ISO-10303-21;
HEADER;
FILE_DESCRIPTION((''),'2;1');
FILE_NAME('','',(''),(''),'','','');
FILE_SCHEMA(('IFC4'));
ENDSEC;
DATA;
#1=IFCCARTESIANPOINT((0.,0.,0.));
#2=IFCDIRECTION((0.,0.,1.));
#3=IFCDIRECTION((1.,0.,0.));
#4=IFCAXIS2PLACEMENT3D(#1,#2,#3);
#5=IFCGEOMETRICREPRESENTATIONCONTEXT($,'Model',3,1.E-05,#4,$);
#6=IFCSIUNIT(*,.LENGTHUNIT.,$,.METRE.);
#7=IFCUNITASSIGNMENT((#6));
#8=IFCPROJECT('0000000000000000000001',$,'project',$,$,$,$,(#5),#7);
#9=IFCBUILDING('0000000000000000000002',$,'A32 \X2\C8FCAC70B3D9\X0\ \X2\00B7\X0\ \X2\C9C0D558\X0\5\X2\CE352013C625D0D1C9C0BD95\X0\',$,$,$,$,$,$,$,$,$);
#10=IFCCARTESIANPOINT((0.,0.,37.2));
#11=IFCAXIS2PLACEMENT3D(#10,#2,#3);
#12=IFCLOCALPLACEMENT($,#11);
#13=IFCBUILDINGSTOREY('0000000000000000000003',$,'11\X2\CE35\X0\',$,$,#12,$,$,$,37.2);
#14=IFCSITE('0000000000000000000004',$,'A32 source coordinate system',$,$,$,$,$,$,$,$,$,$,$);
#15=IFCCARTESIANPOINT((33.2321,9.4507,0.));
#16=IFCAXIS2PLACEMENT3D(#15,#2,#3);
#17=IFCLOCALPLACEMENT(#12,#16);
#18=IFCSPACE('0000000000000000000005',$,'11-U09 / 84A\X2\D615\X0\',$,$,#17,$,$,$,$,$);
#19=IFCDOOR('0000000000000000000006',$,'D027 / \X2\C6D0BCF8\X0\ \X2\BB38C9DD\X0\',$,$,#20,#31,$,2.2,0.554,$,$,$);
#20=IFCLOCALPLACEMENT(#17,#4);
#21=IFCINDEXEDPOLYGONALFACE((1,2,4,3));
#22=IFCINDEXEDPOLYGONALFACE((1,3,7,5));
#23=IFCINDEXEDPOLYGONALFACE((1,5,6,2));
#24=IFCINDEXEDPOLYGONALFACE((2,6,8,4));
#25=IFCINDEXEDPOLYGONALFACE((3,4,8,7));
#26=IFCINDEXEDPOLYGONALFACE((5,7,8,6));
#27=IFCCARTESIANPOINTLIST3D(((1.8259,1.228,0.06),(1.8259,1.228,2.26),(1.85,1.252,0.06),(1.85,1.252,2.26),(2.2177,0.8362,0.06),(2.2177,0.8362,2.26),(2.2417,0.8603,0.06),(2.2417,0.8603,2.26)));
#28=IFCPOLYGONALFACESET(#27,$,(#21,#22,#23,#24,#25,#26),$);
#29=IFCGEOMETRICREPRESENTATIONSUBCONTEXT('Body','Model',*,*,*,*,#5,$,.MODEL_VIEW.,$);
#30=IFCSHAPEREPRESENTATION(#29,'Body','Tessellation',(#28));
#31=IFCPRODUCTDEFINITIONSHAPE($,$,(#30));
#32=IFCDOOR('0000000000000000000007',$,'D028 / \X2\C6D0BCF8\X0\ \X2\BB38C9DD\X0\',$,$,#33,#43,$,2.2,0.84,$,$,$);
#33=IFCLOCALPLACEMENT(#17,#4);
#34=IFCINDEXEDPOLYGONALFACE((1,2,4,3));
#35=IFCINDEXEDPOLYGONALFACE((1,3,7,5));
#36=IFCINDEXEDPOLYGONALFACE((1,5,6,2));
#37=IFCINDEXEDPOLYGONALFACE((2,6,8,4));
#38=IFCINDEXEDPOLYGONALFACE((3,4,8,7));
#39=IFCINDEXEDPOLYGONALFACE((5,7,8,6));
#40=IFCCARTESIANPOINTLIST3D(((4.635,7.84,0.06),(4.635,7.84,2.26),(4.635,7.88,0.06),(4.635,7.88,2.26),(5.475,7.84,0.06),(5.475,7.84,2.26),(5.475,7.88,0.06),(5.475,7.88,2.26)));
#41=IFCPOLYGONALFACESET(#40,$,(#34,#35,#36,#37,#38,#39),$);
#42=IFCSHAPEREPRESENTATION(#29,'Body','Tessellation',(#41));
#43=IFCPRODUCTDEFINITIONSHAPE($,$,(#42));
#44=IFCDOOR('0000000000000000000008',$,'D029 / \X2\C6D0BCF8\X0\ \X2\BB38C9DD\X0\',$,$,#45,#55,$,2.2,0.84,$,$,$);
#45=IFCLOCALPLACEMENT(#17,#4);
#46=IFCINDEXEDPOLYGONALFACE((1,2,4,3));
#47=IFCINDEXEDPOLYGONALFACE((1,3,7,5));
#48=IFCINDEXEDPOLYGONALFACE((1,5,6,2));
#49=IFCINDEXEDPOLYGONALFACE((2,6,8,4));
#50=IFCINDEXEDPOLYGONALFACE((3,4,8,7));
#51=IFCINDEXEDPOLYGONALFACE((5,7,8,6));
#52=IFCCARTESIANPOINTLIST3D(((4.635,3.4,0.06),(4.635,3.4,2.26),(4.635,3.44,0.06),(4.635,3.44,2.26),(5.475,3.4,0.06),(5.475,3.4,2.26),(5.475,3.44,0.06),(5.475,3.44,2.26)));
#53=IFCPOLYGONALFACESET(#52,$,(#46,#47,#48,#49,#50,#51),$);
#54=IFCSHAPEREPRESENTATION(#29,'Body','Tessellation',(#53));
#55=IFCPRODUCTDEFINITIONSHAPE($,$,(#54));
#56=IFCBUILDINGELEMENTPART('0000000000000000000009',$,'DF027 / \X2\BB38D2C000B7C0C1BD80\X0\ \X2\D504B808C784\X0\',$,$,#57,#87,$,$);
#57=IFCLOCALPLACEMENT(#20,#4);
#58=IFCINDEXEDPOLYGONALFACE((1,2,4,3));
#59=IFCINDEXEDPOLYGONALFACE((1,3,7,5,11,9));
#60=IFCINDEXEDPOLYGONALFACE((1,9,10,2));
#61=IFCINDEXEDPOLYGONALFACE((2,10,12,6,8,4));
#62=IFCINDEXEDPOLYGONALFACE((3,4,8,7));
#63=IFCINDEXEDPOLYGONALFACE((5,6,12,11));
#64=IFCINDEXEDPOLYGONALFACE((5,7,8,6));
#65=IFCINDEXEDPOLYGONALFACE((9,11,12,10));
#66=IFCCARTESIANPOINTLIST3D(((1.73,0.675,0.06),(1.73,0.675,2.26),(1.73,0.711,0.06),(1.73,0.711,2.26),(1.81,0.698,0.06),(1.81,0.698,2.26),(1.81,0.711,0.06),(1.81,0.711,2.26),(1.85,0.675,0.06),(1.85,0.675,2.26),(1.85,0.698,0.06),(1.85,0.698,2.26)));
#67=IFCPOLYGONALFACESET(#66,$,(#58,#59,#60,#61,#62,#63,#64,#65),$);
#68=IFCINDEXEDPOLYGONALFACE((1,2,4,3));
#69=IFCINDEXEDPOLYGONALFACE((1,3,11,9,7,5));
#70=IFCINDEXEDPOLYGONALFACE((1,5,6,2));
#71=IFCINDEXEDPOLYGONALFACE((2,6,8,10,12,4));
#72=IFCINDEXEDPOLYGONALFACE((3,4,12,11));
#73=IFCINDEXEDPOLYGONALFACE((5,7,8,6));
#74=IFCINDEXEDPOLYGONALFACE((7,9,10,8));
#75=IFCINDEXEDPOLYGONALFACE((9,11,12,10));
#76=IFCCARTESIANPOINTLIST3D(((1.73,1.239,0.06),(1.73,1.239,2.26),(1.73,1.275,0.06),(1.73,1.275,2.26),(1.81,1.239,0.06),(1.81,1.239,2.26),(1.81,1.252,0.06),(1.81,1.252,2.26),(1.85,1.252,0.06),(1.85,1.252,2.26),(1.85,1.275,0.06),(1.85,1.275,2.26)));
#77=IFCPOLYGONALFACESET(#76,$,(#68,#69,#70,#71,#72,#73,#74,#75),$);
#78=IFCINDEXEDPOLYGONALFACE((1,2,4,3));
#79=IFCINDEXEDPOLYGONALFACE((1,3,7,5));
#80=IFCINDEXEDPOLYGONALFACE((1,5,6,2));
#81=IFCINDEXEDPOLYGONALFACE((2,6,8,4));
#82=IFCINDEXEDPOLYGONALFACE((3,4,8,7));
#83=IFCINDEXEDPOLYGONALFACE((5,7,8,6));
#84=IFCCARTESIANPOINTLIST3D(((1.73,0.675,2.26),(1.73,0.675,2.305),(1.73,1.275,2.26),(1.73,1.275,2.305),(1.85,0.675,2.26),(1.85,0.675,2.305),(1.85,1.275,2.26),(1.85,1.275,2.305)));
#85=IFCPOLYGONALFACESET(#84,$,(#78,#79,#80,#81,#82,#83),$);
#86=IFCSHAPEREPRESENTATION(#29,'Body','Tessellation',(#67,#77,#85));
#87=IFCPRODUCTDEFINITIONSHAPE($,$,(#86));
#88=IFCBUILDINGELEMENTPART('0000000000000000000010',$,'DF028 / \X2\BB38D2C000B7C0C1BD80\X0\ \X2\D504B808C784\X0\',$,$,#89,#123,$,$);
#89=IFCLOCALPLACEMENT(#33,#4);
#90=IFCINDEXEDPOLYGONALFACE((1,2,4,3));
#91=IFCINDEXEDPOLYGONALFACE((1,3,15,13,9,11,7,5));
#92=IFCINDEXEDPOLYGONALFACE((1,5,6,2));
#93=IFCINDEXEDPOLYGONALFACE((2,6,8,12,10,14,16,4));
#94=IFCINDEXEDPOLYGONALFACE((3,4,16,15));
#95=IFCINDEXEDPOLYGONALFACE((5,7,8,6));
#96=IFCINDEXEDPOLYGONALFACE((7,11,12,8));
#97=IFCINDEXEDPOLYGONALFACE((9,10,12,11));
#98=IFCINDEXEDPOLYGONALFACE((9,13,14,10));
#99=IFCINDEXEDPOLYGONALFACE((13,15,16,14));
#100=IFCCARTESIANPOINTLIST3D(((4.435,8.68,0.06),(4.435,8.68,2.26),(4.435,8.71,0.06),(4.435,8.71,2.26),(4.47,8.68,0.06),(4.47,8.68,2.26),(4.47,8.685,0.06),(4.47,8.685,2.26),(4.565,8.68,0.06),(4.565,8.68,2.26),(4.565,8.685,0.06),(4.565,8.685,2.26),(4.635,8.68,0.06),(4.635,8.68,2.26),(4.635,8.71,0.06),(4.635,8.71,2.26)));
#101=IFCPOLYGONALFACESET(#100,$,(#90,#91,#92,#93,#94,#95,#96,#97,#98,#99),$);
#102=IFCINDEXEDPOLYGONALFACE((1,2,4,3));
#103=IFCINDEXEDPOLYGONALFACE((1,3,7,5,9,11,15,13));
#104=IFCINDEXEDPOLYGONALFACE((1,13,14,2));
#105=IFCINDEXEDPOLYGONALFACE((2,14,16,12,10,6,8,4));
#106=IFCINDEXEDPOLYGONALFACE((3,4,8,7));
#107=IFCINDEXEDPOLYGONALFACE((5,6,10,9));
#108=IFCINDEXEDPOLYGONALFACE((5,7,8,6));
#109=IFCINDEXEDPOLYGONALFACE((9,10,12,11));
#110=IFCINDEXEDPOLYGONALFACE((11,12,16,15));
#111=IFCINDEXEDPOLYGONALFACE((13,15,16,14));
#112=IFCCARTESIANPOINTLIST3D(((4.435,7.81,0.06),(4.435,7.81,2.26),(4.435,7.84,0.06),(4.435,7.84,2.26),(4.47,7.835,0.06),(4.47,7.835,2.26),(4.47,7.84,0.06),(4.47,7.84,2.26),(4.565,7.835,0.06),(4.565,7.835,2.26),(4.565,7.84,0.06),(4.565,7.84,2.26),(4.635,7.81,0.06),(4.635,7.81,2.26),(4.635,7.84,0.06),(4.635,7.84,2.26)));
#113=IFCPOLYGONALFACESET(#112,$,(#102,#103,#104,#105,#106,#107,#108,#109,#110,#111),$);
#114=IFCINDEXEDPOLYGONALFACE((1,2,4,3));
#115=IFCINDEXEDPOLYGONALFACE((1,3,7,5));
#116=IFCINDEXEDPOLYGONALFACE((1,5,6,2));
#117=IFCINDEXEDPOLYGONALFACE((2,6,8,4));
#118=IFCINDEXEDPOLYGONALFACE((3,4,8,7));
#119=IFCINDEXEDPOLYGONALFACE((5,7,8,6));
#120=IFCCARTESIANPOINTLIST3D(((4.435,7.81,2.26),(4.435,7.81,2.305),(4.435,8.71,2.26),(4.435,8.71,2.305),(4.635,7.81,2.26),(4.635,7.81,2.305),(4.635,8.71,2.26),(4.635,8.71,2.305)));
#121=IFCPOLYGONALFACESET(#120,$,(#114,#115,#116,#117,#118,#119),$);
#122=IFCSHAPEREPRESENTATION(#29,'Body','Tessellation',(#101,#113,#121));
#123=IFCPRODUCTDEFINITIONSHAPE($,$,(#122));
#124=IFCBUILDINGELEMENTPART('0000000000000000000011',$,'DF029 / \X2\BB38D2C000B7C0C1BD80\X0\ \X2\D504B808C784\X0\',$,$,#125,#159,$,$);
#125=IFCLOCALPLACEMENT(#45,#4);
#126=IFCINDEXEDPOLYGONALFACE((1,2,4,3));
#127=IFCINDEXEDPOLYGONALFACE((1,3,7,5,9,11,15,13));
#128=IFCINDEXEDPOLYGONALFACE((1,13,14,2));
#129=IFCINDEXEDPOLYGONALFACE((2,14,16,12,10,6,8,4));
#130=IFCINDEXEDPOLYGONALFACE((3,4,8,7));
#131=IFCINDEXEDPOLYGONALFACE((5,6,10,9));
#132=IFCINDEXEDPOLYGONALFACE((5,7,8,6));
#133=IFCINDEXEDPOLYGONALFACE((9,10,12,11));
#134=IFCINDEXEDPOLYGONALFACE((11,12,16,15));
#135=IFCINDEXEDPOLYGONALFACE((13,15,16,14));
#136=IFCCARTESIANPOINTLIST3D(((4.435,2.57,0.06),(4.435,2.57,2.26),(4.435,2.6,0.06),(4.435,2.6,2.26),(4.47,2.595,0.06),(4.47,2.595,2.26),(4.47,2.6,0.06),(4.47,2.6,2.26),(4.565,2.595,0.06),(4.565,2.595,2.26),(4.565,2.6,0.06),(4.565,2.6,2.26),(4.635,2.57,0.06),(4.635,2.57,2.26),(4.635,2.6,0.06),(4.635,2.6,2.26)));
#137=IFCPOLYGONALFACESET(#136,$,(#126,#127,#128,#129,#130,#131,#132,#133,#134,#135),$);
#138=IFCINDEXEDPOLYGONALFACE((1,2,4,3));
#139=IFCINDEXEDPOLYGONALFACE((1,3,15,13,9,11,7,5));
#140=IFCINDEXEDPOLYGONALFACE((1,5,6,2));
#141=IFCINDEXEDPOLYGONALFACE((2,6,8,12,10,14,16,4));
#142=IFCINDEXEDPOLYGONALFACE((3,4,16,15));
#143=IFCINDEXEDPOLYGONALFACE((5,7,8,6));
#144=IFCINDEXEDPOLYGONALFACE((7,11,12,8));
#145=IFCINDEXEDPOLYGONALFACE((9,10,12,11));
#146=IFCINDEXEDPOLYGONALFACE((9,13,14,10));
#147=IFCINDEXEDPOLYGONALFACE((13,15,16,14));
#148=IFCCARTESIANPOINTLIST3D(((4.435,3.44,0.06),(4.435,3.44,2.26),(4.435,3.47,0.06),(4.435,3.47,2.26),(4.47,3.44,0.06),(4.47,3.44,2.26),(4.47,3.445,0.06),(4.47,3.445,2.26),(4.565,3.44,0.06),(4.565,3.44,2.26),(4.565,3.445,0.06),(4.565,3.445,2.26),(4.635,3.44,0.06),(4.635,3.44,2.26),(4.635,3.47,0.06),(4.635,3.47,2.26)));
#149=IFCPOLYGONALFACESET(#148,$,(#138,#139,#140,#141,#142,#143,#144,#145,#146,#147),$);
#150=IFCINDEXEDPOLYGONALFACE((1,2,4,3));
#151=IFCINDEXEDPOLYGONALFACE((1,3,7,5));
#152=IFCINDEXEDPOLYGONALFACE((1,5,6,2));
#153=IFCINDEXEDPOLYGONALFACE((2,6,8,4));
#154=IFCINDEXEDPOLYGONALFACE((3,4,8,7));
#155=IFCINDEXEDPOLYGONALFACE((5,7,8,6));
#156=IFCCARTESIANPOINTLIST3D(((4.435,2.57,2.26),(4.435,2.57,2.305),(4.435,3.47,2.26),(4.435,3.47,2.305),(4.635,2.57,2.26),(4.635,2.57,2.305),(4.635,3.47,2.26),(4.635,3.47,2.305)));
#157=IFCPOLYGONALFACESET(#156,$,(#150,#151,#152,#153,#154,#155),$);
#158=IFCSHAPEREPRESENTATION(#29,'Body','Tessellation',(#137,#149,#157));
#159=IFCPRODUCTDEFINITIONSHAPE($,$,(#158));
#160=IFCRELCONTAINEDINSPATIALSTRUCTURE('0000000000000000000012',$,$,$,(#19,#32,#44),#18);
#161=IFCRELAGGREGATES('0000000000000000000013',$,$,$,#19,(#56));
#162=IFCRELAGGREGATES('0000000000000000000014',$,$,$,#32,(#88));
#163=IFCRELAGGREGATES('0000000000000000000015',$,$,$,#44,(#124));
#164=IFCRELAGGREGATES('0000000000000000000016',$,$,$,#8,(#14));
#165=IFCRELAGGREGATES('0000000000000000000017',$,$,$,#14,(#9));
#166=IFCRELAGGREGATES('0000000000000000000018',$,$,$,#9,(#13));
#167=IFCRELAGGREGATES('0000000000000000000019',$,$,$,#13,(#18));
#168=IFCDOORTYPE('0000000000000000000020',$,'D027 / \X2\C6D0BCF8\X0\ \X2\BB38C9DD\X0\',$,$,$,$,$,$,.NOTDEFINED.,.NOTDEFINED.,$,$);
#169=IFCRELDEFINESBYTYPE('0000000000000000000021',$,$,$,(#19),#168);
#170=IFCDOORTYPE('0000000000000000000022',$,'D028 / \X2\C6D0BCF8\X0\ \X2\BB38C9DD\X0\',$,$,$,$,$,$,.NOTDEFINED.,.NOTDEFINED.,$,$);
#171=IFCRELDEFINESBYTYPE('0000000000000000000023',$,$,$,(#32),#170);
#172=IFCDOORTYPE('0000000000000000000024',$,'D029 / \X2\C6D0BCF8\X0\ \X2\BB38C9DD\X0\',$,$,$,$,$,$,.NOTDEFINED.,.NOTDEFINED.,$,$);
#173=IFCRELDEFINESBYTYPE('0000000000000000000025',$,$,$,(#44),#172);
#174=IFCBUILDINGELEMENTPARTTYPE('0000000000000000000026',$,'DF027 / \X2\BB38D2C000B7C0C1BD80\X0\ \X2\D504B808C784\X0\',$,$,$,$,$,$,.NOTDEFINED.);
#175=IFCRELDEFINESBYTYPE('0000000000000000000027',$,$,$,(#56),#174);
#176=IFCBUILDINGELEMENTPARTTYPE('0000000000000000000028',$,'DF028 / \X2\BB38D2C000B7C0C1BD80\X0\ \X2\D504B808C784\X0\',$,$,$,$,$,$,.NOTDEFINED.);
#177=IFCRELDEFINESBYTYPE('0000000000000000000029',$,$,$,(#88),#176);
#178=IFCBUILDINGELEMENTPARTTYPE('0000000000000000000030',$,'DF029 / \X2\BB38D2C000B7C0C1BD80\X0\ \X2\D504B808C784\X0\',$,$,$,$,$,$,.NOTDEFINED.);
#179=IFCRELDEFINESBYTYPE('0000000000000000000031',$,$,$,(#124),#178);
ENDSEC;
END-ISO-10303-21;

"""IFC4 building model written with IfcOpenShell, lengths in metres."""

from ifc_helpers import new_model, si_unit, frame, origin, origin_with_axes, place, context, subcontext, project, spatial, polyline, outline, extrude, source, transform, mapped, type_object, type_shapes, element, aggregate, save


model = new_model("IFC4")

# Units and contexts
model_context = context("Model", 3, precision=1e-05, world=origin_with_axes())
body_context = subcontext(model_context, "Body", "Model", "MODEL_VIEW")
ifc_project = project(units=[si_unit("LENGTHUNIT", "METRE")], contexts=[model_context])

# Site, building, storey, space
storey_placement = place(None, frame((0.0, 0.0, 37.2), z_axis=(0.0, 0.0, 1.0), x_axis=(1.0, 0.0, 0.0)))
space_placement = place(storey_placement, frame((33.2321, 9.4507, 0.0), z_axis=(0.0, 0.0, 1.0), x_axis=(1.0, 0.0, 0.0)))
site = spatial("IfcSite", under=ifc_project, Name="A32 source coordinate system")
building = spatial("IfcBuilding", under=site, Name="A32 주거동 · 지하5층–옥탑지붕")
storey = spatial("IfcBuildingStorey", under=building, at=storey_placement, Name="11층", Elevation=37.2)
space = spatial("IfcSpace", under=storey, at=space_placement, Name="11-U09 / 84A형")

# Doors
door_type_1 = type_object("IfcDoorType", Name="D027 / 원본 문짝", OperationType="NOTDEFINED", PredefinedType="NOTDEFINED")
shared_shape_1 = source(origin(), body_context, "Body", "SweptSolid", [
    extrude(outline(polyline([(1.85, 1.252), (2.2417, 0.8603), (2.2177, 0.8362), (1.8259, 1.228), (1.85, 1.252)])), frame((0.0, 0.0, 0.06)), (0.0, 0.0, 1.0), 2.2),
])
type_shapes(door_type_1, [shared_shape_1])
door_1_placement = place(space_placement, origin_with_axes())
door_1 = element("IfcDoor", 1, at=door_1_placement, inside=space, type_object=door_type_1, Name="D027 / 원본 문짝", OverallHeight=2.2, OverallWidth=0.554, context=body_context, shape_type="MappedRepresentation", body=[
    mapped(shared_shape_1, transform((0.0, 0.0, 0.0), scale=1.0)),
])
door_type_2 = type_object("IfcDoorType", Name="D028 / 원본 문짝", OperationType="NOTDEFINED", PredefinedType="NOTDEFINED")
shared_shape_2 = source(origin(), body_context, "Body", "SweptSolid", [
    extrude(outline(polyline([(5.475, 7.88), (5.475, 7.84), (4.635, 7.84), (4.635, 7.88), (5.475, 7.88)])), frame((0.0, 0.0, 0.06)), (0.0, 0.0, 1.0), 2.2),
])
type_shapes(door_type_2, [shared_shape_2])
door_2_placement = place(space_placement, origin_with_axes())
door_2 = element("IfcDoor", 2, at=door_2_placement, inside=space, type_object=door_type_2, Name="D028 / 원본 문짝", OverallHeight=2.2, OverallWidth=0.84, context=body_context, shape_type="MappedRepresentation", body=[
    mapped(shared_shape_2, transform((0.0, 0.0, 0.0), scale=1.0)),
])
door_type_3 = type_object("IfcDoorType", Name="D029 / 원본 문짝", OperationType="NOTDEFINED", PredefinedType="NOTDEFINED")
shared_shape_3 = source(origin(), body_context, "Body", "SweptSolid", [
    extrude(outline(polyline([(4.635, 3.44), (5.475, 3.44), (5.475, 3.4), (4.635, 3.4), (4.635, 3.44)])), frame((0.0, 0.0, 0.06)), (0.0, 0.0, 1.0), 2.2),
])
type_shapes(door_type_3, [shared_shape_3])
door_3_placement = place(space_placement, origin_with_axes())
door_3 = element("IfcDoor", 3, at=door_3_placement, inside=space, type_object=door_type_3, Name="D029 / 원본 문짝", OverallHeight=2.2, OverallWidth=0.84, context=body_context, shape_type="MappedRepresentation", body=[
    mapped(shared_shape_3, transform((0.0, 0.0, 0.0), scale=1.0)),
])

# Building element parts
building_element_part_type_1 = type_object("IfcBuildingElementPartType", Name="DF027 / 문틀·상부 프레임", PredefinedType="NOTDEFINED")
shared_shape_4 = source(origin(), body_context, "Body", "SweptSolid", [
    extrude(outline(polyline([(1.73, 0.711), (1.81, 0.711), (1.81, 0.698), (1.85, 0.698), (1.85, 0.675), (1.73, 0.675), (1.73, 0.711)])), frame((0.0, 0.0, 0.06)), (0.0, 0.0, 1.0), 2.2),
    extrude(outline(polyline([(1.85, 1.275), (1.85, 1.252), (1.81, 1.252), (1.81, 1.239), (1.73, 1.239), (1.73, 1.275), (1.85, 1.275)])), frame((0.0, 0.0, 0.06)), (0.0, 0.0, 1.0), 2.2),
    extrude(outline(polyline([(1.73, 0.675), (1.73, 1.275), (1.85, 1.275), (1.85, 0.675), (1.73, 0.675)])), frame((0.0, 0.0, 2.26)), (0.0, 0.0, 1.0), 0.045),
])
type_shapes(building_element_part_type_1, [shared_shape_4])
building_element_part_1_placement = place(door_1_placement, origin_with_axes())
building_element_part_1 = element("IfcBuildingElementPart", 4, at=building_element_part_1_placement, type_object=building_element_part_type_1, Name="DF027 / 문틀·상부 프레임", context=body_context, shape_type="MappedRepresentation", body=[
    mapped(shared_shape_4, transform((0.0, 0.0, 0.0), scale=1.0)),
])
aggregate(door_1, [building_element_part_1])
building_element_part_type_2 = type_object("IfcBuildingElementPartType", Name="DF028 / 문틀·상부 프레임", PredefinedType="NOTDEFINED")
shared_shape_5 = source(origin(), body_context, "Body", "SweptSolid", [
    extrude(outline(polyline([(4.635, 8.68), (4.565, 8.68), (4.565, 8.685), (4.47, 8.685), (4.47, 8.68), (4.435, 8.68), (4.435, 8.71), (4.635, 8.71), (4.635, 8.68)])), frame((0.0, 0.0, 0.06)), (0.0, 0.0, 1.0), 2.2),
    extrude(outline(polyline([(4.435, 7.81), (4.435, 7.84), (4.47, 7.84), (4.47, 7.835), (4.565, 7.835), (4.565, 7.84), (4.635, 7.84), (4.635, 7.81), (4.435, 7.81)])), frame((0.0, 0.0, 0.06)), (0.0, 0.0, 1.0), 2.2),
    extrude(outline(polyline([(4.435, 7.81), (4.435, 8.71), (4.635, 8.71), (4.635, 7.81), (4.435, 7.81)])), frame((0.0, 0.0, 2.26)), (0.0, 0.0, 1.0), 0.045),
])
type_shapes(building_element_part_type_2, [shared_shape_5])
building_element_part_2_placement = place(door_2_placement, origin_with_axes())
building_element_part_2 = element("IfcBuildingElementPart", 5, at=building_element_part_2_placement, type_object=building_element_part_type_2, Name="DF028 / 문틀·상부 프레임", context=body_context, shape_type="MappedRepresentation", body=[
    mapped(shared_shape_5, transform((0.0, 0.0, 0.0), scale=1.0)),
])
aggregate(door_2, [building_element_part_2])
building_element_part_type_3 = type_object("IfcBuildingElementPartType", Name="DF029 / 문틀·상부 프레임", PredefinedType="NOTDEFINED")
shared_shape_6 = source(origin(), body_context, "Body", "SweptSolid", [
    extrude(outline(polyline([(4.435, 2.57), (4.435, 2.6), (4.47, 2.6), (4.47, 2.595), (4.565, 2.595), (4.565, 2.6), (4.635, 2.6), (4.635, 2.57), (4.435, 2.57)])), frame((0.0, 0.0, 0.06)), (0.0, 0.0, 1.0), 2.2),
    extrude(outline(polyline([(4.635, 3.44), (4.565, 3.44), (4.565, 3.445), (4.47, 3.445), (4.47, 3.44), (4.435, 3.44), (4.435, 3.47), (4.635, 3.47), (4.635, 3.44)])), frame((0.0, 0.0, 0.06)), (0.0, 0.0, 1.0), 2.2),
    extrude(outline(polyline([(4.435, 2.57), (4.435, 3.47), (4.635, 3.47), (4.635, 2.57), (4.435, 2.57)])), frame((0.0, 0.0, 2.26)), (0.0, 0.0, 1.0), 0.045),
])
type_shapes(building_element_part_type_3, [shared_shape_6])
building_element_part_3_placement = place(door_3_placement, origin_with_axes())
building_element_part_3 = element("IfcBuildingElementPart", 6, at=building_element_part_3_placement, type_object=building_element_part_type_3, Name="DF029 / 문틀·상부 프레임", context=body_context, shape_type="MappedRepresentation", body=[
    mapped(shared_shape_6, transform((0.0, 0.0, 0.0), scale=1.0)),
])
aggregate(door_3, [building_element_part_3])

save(model, "model.ifc")
